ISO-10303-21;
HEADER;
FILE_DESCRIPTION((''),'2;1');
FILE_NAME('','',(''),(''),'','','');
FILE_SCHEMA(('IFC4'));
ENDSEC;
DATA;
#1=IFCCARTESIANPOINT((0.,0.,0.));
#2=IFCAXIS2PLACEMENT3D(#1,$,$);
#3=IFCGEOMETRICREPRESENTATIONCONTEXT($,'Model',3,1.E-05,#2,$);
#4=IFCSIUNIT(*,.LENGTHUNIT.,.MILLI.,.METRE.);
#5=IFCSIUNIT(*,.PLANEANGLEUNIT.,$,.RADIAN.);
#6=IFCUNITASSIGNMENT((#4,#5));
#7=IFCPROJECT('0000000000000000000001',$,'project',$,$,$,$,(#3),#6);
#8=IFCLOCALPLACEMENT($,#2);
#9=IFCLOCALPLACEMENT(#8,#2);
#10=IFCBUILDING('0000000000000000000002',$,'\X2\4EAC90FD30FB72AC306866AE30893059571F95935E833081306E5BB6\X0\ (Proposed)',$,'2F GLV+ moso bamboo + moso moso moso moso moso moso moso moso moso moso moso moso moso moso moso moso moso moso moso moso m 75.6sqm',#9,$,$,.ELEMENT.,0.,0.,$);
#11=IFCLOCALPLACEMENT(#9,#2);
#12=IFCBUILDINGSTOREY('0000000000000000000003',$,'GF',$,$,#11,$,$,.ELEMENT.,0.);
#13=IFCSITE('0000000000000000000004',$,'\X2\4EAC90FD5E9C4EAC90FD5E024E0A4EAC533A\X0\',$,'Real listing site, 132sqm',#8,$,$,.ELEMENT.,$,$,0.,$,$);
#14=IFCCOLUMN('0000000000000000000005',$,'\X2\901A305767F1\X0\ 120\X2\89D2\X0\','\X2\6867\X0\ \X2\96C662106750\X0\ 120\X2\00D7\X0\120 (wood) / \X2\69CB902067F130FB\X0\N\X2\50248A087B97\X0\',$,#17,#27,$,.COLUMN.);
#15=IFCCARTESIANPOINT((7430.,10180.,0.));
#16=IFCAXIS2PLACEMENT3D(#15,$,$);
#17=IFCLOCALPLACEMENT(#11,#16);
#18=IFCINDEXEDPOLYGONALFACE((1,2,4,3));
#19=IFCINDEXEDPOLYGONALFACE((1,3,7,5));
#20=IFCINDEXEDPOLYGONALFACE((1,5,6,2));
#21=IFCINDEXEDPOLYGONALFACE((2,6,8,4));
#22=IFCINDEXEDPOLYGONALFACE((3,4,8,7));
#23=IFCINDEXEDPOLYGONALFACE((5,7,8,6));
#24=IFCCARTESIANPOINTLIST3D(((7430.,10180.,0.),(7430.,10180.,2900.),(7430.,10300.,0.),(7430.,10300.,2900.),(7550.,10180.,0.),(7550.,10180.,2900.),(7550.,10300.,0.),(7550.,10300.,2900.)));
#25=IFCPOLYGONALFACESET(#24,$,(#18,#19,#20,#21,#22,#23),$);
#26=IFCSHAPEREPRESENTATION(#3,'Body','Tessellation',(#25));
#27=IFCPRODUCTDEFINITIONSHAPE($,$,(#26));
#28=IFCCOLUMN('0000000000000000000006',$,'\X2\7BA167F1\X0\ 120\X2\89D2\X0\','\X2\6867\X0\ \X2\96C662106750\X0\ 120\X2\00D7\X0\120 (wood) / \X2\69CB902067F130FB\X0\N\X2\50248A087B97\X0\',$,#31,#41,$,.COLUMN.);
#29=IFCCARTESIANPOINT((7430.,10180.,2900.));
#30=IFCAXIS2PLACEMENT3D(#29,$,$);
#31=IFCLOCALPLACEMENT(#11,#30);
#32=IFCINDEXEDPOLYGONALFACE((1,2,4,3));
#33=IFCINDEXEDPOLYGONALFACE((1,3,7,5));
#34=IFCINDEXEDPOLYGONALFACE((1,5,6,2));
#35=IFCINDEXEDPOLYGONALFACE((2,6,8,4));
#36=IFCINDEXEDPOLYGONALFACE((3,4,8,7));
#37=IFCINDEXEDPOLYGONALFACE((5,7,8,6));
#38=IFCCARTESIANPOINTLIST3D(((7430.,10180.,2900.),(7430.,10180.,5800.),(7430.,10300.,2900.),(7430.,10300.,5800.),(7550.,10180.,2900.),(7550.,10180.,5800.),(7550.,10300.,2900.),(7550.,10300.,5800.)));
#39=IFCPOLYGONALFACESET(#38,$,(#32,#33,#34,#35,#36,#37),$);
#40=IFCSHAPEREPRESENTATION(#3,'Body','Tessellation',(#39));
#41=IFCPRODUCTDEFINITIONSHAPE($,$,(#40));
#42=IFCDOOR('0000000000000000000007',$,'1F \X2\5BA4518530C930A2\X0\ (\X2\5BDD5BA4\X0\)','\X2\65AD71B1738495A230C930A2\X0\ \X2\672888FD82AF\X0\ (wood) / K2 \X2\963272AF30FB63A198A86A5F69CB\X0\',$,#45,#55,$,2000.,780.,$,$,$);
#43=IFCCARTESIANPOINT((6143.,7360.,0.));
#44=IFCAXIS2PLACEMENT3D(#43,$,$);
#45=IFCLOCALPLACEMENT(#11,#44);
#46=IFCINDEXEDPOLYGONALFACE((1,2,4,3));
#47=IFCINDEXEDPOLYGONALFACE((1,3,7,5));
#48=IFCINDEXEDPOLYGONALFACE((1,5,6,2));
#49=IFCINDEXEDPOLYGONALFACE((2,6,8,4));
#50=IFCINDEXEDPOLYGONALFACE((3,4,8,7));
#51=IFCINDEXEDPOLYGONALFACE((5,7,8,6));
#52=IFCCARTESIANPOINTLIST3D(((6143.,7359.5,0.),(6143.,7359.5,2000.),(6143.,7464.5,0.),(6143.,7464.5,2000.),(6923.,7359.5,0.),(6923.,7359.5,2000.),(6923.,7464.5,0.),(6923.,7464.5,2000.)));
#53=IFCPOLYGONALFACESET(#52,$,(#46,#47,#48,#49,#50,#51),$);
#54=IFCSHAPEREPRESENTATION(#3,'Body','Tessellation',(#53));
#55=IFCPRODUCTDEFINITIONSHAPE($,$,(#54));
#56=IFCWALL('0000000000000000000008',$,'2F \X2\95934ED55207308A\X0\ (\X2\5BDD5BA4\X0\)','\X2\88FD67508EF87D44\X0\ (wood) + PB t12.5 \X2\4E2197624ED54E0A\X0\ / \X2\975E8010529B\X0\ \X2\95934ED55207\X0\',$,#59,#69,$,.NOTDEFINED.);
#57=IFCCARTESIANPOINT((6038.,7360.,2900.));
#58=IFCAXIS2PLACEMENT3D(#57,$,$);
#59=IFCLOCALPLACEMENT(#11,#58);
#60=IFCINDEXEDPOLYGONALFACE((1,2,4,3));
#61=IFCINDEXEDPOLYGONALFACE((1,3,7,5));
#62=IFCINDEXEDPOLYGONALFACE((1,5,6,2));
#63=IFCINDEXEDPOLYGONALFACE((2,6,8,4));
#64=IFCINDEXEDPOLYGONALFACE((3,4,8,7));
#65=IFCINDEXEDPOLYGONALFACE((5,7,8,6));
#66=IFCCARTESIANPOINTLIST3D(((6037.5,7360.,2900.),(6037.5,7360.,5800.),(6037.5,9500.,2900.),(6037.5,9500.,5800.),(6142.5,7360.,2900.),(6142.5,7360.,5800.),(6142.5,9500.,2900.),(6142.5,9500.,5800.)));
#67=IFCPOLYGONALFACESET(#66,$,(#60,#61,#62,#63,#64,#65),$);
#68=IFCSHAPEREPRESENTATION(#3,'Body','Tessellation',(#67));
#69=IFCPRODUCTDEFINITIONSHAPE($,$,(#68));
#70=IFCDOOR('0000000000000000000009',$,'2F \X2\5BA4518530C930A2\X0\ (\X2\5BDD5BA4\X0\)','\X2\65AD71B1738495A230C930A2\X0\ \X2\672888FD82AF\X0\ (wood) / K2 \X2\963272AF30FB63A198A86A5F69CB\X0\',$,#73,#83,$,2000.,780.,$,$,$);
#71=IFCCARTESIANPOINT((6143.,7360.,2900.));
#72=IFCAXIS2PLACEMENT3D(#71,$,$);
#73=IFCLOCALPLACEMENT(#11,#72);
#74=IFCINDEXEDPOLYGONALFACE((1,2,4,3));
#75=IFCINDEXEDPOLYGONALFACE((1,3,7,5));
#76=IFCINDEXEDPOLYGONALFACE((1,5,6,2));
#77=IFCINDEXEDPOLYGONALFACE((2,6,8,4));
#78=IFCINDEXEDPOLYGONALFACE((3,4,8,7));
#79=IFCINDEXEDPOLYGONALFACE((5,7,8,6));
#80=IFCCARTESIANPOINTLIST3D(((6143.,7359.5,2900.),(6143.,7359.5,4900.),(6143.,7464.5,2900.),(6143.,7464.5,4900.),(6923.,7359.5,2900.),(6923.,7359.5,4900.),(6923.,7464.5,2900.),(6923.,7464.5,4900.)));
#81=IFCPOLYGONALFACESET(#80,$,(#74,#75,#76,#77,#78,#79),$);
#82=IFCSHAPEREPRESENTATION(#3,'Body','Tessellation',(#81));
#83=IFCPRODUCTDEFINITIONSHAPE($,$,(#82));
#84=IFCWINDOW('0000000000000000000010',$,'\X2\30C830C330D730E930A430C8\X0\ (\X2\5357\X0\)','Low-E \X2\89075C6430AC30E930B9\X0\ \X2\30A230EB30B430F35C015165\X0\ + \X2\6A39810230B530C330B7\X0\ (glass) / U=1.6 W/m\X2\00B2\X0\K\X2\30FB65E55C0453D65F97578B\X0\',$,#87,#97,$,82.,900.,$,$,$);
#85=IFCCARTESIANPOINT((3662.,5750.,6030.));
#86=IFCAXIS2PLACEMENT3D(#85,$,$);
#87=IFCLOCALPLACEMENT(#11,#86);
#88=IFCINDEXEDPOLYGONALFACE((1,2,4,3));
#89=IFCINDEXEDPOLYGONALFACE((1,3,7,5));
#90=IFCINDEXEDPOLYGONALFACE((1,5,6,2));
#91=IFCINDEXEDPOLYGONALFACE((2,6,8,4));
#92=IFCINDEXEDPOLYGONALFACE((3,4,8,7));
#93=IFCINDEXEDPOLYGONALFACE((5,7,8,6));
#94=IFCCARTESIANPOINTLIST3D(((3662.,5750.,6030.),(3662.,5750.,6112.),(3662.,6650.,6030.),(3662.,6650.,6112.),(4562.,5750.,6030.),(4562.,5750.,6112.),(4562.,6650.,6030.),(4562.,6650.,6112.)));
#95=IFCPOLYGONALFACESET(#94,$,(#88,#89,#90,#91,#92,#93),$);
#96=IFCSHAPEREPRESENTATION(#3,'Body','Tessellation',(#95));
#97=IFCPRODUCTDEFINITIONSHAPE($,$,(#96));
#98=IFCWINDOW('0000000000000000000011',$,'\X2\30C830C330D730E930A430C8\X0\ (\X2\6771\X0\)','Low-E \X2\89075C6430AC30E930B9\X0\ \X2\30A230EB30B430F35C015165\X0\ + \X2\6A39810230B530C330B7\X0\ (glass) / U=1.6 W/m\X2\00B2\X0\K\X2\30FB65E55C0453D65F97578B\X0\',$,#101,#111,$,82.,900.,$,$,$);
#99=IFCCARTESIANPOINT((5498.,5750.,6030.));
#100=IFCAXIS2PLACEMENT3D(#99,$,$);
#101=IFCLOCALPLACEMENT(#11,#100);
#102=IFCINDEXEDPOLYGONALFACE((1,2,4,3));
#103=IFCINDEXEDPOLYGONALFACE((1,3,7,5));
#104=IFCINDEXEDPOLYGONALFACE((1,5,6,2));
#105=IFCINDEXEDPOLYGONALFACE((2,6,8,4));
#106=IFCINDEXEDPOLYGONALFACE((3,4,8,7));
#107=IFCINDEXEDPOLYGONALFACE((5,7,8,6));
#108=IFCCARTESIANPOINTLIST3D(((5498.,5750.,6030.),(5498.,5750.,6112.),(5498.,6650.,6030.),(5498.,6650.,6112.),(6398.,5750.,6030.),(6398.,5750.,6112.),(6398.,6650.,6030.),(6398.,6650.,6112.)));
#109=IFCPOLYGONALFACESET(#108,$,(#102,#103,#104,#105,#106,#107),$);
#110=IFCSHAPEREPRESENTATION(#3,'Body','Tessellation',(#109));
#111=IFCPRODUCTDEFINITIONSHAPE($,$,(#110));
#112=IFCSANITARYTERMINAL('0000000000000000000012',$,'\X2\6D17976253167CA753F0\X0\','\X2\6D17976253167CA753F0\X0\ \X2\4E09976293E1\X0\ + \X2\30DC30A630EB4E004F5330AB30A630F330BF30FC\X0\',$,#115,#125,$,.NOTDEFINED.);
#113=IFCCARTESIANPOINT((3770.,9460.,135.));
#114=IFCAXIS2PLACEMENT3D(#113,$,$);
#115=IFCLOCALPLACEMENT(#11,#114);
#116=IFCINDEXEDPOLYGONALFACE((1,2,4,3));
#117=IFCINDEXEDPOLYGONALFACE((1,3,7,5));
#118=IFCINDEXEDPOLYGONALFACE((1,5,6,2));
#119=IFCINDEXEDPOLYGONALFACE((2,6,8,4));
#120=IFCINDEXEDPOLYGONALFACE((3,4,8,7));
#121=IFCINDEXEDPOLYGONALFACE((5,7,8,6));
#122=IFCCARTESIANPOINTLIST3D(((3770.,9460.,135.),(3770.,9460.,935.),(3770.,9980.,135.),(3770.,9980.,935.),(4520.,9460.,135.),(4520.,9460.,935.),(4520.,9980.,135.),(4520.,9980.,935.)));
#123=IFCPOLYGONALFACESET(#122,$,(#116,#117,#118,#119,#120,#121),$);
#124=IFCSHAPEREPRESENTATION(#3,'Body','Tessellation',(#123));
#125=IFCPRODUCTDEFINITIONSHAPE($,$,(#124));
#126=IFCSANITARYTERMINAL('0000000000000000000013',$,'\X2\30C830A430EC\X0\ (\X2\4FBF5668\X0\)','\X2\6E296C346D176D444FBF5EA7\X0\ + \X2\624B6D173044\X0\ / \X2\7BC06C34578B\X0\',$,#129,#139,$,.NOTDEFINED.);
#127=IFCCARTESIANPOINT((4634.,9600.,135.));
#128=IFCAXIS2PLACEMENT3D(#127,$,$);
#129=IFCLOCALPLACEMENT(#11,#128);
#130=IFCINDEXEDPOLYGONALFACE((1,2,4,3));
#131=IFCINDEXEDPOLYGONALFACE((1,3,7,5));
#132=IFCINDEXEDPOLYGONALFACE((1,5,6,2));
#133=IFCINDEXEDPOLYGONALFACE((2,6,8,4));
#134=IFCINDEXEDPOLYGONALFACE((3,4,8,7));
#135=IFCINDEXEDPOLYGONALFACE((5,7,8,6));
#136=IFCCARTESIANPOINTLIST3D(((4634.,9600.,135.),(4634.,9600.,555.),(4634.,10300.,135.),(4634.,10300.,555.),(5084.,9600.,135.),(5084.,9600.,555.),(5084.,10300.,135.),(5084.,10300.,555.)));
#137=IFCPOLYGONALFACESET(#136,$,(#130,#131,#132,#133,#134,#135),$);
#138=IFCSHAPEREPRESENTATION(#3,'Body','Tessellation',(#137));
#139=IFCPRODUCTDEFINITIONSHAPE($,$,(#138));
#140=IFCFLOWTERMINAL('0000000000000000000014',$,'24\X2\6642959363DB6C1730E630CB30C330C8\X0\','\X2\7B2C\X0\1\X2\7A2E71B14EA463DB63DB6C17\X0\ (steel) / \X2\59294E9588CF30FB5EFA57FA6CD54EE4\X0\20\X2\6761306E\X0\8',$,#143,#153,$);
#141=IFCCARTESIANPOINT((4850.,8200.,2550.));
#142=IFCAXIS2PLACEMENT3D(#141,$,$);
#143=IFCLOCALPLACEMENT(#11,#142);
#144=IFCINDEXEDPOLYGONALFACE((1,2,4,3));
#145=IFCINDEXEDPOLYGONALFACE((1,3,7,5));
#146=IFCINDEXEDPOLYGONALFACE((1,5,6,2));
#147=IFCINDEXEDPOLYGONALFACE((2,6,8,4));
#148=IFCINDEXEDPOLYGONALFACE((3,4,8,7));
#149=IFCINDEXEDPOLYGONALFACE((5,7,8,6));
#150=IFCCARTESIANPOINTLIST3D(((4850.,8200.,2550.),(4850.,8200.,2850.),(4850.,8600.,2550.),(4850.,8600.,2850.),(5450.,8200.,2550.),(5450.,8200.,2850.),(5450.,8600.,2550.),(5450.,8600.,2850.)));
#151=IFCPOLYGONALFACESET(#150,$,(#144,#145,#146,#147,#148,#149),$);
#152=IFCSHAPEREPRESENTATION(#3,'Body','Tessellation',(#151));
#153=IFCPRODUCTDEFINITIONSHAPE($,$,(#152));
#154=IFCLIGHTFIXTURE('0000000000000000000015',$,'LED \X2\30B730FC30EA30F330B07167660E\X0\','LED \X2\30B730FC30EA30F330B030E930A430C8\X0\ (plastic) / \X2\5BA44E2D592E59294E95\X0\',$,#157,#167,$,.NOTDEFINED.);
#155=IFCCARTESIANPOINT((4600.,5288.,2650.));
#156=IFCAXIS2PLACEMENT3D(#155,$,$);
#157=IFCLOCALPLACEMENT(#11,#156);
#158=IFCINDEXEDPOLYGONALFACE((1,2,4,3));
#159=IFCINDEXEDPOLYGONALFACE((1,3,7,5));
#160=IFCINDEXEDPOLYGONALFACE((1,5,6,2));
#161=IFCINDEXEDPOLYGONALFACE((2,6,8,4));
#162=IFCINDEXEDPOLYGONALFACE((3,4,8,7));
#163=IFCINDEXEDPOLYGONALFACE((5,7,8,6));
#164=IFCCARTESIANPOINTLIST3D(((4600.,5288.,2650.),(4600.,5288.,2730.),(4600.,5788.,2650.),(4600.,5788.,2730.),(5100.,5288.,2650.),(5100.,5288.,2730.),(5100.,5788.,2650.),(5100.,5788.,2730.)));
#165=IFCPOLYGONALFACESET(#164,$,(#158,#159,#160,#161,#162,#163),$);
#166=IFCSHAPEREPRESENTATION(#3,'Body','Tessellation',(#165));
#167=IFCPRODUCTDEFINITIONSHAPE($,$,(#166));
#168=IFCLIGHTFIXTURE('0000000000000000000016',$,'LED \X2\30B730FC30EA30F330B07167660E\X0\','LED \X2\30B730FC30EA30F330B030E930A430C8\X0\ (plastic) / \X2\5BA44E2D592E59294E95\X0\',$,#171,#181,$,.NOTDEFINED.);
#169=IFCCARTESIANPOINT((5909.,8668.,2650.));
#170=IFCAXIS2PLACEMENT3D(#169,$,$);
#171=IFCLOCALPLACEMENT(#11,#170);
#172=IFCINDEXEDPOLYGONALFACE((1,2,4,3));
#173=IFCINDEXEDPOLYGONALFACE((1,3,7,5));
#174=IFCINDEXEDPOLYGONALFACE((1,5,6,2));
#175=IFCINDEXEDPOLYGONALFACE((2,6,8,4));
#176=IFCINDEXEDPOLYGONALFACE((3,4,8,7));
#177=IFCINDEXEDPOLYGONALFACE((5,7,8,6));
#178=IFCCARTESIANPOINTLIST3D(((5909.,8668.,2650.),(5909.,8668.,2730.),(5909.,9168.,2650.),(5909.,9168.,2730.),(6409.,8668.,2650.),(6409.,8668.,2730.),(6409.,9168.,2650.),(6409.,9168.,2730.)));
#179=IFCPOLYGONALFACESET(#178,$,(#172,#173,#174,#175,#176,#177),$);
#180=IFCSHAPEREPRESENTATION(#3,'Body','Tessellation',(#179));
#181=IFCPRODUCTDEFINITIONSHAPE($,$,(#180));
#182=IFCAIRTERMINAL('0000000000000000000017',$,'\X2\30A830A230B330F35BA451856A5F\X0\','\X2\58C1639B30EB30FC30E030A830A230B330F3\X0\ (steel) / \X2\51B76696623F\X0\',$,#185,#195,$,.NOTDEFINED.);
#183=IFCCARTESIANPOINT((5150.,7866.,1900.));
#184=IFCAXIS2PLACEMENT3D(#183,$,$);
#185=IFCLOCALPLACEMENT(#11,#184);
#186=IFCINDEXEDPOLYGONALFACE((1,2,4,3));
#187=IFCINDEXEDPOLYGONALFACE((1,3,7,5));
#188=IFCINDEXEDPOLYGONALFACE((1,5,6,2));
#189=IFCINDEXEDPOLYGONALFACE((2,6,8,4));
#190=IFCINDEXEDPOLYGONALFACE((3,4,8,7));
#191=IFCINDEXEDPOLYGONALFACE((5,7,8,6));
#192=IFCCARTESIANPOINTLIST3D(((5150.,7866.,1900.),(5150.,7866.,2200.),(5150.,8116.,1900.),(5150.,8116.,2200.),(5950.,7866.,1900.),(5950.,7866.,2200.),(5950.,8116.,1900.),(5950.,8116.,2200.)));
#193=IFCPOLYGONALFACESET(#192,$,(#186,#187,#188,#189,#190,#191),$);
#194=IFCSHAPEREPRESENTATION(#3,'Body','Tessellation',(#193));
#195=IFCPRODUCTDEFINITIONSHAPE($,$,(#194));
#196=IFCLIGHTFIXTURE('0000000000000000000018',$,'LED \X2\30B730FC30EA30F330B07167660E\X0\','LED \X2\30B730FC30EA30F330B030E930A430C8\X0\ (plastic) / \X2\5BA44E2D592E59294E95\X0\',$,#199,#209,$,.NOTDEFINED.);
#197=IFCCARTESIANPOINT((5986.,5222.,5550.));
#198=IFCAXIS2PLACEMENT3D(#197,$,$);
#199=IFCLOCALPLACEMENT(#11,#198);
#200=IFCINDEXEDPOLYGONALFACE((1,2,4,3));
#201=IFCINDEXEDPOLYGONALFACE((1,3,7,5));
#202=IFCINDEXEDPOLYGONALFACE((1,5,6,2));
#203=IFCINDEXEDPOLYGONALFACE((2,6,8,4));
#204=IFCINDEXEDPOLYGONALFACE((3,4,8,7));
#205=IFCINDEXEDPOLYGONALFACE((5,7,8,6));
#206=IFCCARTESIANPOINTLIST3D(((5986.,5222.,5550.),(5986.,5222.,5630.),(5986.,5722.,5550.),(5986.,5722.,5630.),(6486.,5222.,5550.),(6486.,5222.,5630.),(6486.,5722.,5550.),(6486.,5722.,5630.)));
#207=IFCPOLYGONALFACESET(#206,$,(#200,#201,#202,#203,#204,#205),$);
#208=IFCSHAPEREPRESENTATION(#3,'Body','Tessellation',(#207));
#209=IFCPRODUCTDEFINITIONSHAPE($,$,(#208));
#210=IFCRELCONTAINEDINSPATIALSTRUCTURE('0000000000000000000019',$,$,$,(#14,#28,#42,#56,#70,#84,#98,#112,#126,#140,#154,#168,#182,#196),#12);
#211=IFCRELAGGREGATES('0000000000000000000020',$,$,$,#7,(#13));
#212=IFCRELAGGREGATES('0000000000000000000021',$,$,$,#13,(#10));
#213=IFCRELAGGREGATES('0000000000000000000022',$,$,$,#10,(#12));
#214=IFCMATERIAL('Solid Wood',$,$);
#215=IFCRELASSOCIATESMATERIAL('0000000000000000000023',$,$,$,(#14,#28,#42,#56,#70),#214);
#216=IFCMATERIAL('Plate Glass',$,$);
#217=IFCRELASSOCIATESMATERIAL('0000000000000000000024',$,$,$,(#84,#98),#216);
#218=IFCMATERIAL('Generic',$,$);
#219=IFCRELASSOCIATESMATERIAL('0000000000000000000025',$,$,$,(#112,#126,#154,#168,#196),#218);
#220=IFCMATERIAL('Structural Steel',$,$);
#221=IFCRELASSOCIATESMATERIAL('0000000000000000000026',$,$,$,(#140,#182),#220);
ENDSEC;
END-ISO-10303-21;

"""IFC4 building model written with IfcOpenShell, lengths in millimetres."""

from ifc_helpers import new_model, si_unit, frame, frame_2d, origin, place, context, project, spatial, rectangle, extrude, material, element, save


model = new_model("IFC4")

# Units and contexts
model_context = context("Model", 3, precision=1e-05, world=origin())
ifc_project = project(units=[si_unit("LENGTHUNIT", "METRE", prefix="MILLI"), si_unit("PLANEANGLEUNIT", "RADIAN")], contexts=[model_context])

# Site, building, storey
site_placement = place(None, origin())
site = spatial("IfcSite", under=ifc_project, at=site_placement, Name="京都府京都市上京区", ObjectType="Real listing site, 132sqm", CompositionType="ELEMENT", RefElevation=0.0)
building_placement = place(site_placement, origin())
building = spatial("IfcBuilding", under=site, at=building_placement, Name="京都・犬と暮らす土間広めの家 (Proposed)", ObjectType="2F GLV+ moso bamboo + moso moso moso moso moso moso moso moso moso moso moso moso moso moso moso moso moso moso moso moso m 75.6sqm", CompositionType="ELEMENT", ElevationOfRefHeight=0.0, ElevationOfTerrain=0.0)
storey_placement = place(building_placement, origin())
storey = spatial("IfcBuildingStorey", under=building, at=storey_placement, Name="GF", CompositionType="ELEMENT", Elevation=0.0)

# Columns
ifc_material_1 = material(Name="Solid Wood")
column_1_placement = place(storey_placement, frame((7430.0, 10180.0, 0.0)))
element("IfcColumn", 1, at=column_1_placement, inside=storey, material=ifc_material_1, Name="通し柱 120角", Description="桧 集成材 120×120 (wood) / 構造柱・N値計算", PredefinedType="COLUMN", context=model_context, shape_type="SweptSolid", body=[
    extrude(rectangle(XDim=120.0, YDim=120.0, at=frame_2d((60.0, 60.0))), frame((7430.0, 10180.0, 0.0)), (0.0, 0.0, 1.0), 2900.0),
])
column_2_placement = place(storey_placement, frame((7430.0, 10180.0, 2900.0)))
element("IfcColumn", 2, at=column_2_placement, inside=storey, material=ifc_material_1, Name="管柱 120角", Description="桧 集成材 120×120 (wood) / 構造柱・N値計算", PredefinedType="COLUMN", context=model_context, shape_type="SweptSolid", body=[
    extrude(rectangle(XDim=120.0, YDim=120.0, at=frame_2d((60.0, 60.0))), frame((7430.0, 10180.0, 2900.0)), (0.0, 0.0, 1.0), 2900.0),
])

# Door
door_1_placement = place(storey_placement, frame((6143.0, 7360.0, 0.0)))
element("IfcDoor", 3, at=door_1_placement, inside=storey, material=ifc_material_1, Name="1F 室内ドア (寝室)", Description="断熱玄関ドア 木製芯 (wood) / K2 防犯・採風機構", OverallHeight=2000.0, OverallWidth=780.0, context=model_context, shape_type="SweptSolid", body=[
    extrude(rectangle(XDim=780.0, YDim=105.0, at=frame_2d((390.0, 52.0))), frame((6143.0, 7360.0, 0.0)), (0.0, 0.0, 1.0), 2000.0),
])

# Wall
wall_1_placement = place(storey_placement, frame((6038.0, 7360.0, 2900.0)))
element("IfcWall", 4, at=wall_1_placement, inside=storey, material=ifc_material_1, Name="2F 間仕切り (寝室)", Description="製材軸組 (wood) + PB t12.5 両面仕上 / 非耐力 間仕切", PredefinedType="NOTDEFINED", context=model_context, shape_type="SweptSolid", body=[
    extrude(rectangle(XDim=105.0, YDim=2140.0, at=frame_2d((52.0, 1070.0))), frame((6038.0, 7360.0, 2900.0)), (0.0, 0.0, 1.0), 2900.0),
])

# Door
door_2_placement = place(storey_placement, frame((6143.0, 7360.0, 2900.0)))
element("IfcDoor", 5, at=door_2_placement, inside=storey, material=ifc_material_1, Name="2F 室内ドア (寝室)", Description="断熱玄関ドア 木製芯 (wood) / K2 防犯・採風機構", OverallHeight=2000.0, OverallWidth=780.0, context=model_context, shape_type="SweptSolid", body=[
    extrude(rectangle(XDim=780.0, YDim=105.0, at=frame_2d((390.0, 52.0))), frame((6143.0, 7360.0, 2900.0)), (0.0, 0.0, 1.0), 2000.0),
])

# Windows
ifc_material_2 = material(Name="Plate Glass")
window_1_placement = place(storey_placement, frame((3662.0, 5750.0, 6030.0)))
element("IfcWindow", 6, at=window_1_placement, inside=storey, material=ifc_material_2, Name="トップライト (南)", Description="Low-E 複層ガラス アルゴン封入 + 樹脂サッシ (glass) / U=1.6 W/m²K・日射取得型", OverallHeight=82.0, OverallWidth=900.0, context=model_context, shape_type="SweptSolid", body=[
    extrude(rectangle(XDim=900.0, YDim=900.0, at=frame_2d((450.0, 450.0))), frame((3662.0, 5750.0, 6030.0)), (0.0, 0.0, 1.0), 82.0),
])
window_2_placement = place(storey_placement, frame((5498.0, 5750.0, 6030.0)))
element("IfcWindow", 7, at=window_2_placement, inside=storey, material=ifc_material_2, Name="トップライト (東)", Description="Low-E 複層ガラス アルゴン封入 + 樹脂サッシ (glass) / U=1.6 W/m²K・日射取得型", OverallHeight=82.0, OverallWidth=900.0, context=model_context, shape_type="SweptSolid", body=[
    extrude(rectangle(XDim=900.0, YDim=900.0, at=frame_2d((450.0, 450.0))), frame((5498.0, 5750.0, 6030.0)), (0.0, 0.0, 1.0), 82.0),
])

# Sanitary terminals
ifc_material_3 = material(Name="Generic")
sanitary_terminal_1_placement = place(storey_placement, frame((3770.0, 9460.0, 135.0)))
element("IfcSanitaryTerminal", 8, at=sanitary_terminal_1_placement, inside=storey, material=ifc_material_3, Name="洗面化粧台", Description="洗面化粧台 三面鏡 + ボウル一体カウンター", PredefinedType="NOTDEFINED", context=model_context, shape_type="SweptSolid", body=[
    extrude(rectangle(XDim=750.0, YDim=520.0, at=frame_2d((375.0, 260.0))), frame((3770.0, 9460.0, 135.0)), (0.0, 0.0, 1.0), 800.0),
])
sanitary_terminal_2_placement = place(storey_placement, frame((4634.0, 9600.0, 135.0)))
element("IfcSanitaryTerminal", 9, at=sanitary_terminal_2_placement, inside=storey, material=ifc_material_3, Name="トイレ (便器)", Description="温水洗浄便座 + 手洗い / 節水型", PredefinedType="NOTDEFINED", context=model_context, shape_type="SweptSolid", body=[
    extrude(rectangle(XDim=450.0, YDim=700.0, at=frame_2d((225.0, 350.0))), frame((4634.0, 9600.0, 135.0)), (0.0, 0.0, 1.0), 420.0),
])

# Flow terminal
ifc_material_4 = material(Name="Structural Steel")
flow_terminal_placement = place(storey_placement, frame((4850.0, 8200.0, 2550.0)))
element("IfcFlowTerminal", 10, at=flow_terminal_placement, inside=storey, material=ifc_material_4, Name="24時間換気ユニット", Description="第1種熱交換換気 (steel) / 天井裏・建基法令20条の8", context=model_context, shape_type="SweptSolid", body=[
    extrude(rectangle(XDim=600.0, YDim=400.0, at=frame_2d((300.0, 200.0))), frame((4850.0, 8200.0, 2550.0)), (0.0, 0.0, 1.0), 300.0),
])

# Light fixtures
light_fixture_1_placement = place(storey_placement, frame((4600.0, 5288.0, 2650.0)))
element("IfcLightFixture", 11, at=light_fixture_1_placement, inside=storey, material=ifc_material_3, Name="LED シーリング照明", Description="LED シーリングライト (plastic) / 室中央天井", PredefinedType="NOTDEFINED", context=model_context, shape_type="SweptSolid", body=[
    extrude(rectangle(XDim=500.0, YDim=500.0, at=frame_2d((250.0, 250.0))), frame((4600.0, 5288.0, 2650.0)), (0.0, 0.0, 1.0), 80.0),
])
light_fixture_2_placement = place(storey_placement, frame((5909.0, 8668.0, 2650.0)))
element("IfcLightFixture", 12, at=light_fixture_2_placement, inside=storey, material=ifc_material_3, Name="LED シーリング照明", Description="LED シーリングライト (plastic) / 室中央天井", PredefinedType="NOTDEFINED", context=model_context, shape_type="SweptSolid", body=[
    extrude(rectangle(XDim=500.0, YDim=500.0, at=frame_2d((250.0, 250.0))), frame((5909.0, 8668.0, 2650.0)), (0.0, 0.0, 1.0), 80.0),
])

# Air terminal
air_terminal_placement = place(storey_placement, frame((5150.0, 7866.0, 1900.0)))
element("IfcAirTerminal", 13, at=air_terminal_placement, inside=storey, material=ifc_material_4, Name="エアコン室内機", Description="壁掛ルームエアコン (steel) / 冷暖房", PredefinedType="NOTDEFINED", context=model_context, shape_type="SweptSolid", body=[
    extrude(rectangle(XDim=800.0, YDim=250.0, at=frame_2d((400.0, 125.0))), frame((5150.0, 7866.0, 1900.0)), (0.0, 0.0, 1.0), 300.0),
])

# Light fixture
light_fixture_3_placement = place(storey_placement, frame((5986.0, 5222.0, 5550.0)))
element("IfcLightFixture", 14, at=light_fixture_3_placement, inside=storey, material=ifc_material_3, Name="LED シーリング照明", Description="LED シーリングライト (plastic) / 室中央天井", PredefinedType="NOTDEFINED", context=model_context, shape_type="SweptSolid", body=[
    extrude(rectangle(XDim=500.0, YDim=500.0, at=frame_2d((250.0, 250.0))), frame((5986.0, 5222.0, 5550.0)), (0.0, 0.0, 1.0), 80.0),
])

save(model, "model.ifc")
